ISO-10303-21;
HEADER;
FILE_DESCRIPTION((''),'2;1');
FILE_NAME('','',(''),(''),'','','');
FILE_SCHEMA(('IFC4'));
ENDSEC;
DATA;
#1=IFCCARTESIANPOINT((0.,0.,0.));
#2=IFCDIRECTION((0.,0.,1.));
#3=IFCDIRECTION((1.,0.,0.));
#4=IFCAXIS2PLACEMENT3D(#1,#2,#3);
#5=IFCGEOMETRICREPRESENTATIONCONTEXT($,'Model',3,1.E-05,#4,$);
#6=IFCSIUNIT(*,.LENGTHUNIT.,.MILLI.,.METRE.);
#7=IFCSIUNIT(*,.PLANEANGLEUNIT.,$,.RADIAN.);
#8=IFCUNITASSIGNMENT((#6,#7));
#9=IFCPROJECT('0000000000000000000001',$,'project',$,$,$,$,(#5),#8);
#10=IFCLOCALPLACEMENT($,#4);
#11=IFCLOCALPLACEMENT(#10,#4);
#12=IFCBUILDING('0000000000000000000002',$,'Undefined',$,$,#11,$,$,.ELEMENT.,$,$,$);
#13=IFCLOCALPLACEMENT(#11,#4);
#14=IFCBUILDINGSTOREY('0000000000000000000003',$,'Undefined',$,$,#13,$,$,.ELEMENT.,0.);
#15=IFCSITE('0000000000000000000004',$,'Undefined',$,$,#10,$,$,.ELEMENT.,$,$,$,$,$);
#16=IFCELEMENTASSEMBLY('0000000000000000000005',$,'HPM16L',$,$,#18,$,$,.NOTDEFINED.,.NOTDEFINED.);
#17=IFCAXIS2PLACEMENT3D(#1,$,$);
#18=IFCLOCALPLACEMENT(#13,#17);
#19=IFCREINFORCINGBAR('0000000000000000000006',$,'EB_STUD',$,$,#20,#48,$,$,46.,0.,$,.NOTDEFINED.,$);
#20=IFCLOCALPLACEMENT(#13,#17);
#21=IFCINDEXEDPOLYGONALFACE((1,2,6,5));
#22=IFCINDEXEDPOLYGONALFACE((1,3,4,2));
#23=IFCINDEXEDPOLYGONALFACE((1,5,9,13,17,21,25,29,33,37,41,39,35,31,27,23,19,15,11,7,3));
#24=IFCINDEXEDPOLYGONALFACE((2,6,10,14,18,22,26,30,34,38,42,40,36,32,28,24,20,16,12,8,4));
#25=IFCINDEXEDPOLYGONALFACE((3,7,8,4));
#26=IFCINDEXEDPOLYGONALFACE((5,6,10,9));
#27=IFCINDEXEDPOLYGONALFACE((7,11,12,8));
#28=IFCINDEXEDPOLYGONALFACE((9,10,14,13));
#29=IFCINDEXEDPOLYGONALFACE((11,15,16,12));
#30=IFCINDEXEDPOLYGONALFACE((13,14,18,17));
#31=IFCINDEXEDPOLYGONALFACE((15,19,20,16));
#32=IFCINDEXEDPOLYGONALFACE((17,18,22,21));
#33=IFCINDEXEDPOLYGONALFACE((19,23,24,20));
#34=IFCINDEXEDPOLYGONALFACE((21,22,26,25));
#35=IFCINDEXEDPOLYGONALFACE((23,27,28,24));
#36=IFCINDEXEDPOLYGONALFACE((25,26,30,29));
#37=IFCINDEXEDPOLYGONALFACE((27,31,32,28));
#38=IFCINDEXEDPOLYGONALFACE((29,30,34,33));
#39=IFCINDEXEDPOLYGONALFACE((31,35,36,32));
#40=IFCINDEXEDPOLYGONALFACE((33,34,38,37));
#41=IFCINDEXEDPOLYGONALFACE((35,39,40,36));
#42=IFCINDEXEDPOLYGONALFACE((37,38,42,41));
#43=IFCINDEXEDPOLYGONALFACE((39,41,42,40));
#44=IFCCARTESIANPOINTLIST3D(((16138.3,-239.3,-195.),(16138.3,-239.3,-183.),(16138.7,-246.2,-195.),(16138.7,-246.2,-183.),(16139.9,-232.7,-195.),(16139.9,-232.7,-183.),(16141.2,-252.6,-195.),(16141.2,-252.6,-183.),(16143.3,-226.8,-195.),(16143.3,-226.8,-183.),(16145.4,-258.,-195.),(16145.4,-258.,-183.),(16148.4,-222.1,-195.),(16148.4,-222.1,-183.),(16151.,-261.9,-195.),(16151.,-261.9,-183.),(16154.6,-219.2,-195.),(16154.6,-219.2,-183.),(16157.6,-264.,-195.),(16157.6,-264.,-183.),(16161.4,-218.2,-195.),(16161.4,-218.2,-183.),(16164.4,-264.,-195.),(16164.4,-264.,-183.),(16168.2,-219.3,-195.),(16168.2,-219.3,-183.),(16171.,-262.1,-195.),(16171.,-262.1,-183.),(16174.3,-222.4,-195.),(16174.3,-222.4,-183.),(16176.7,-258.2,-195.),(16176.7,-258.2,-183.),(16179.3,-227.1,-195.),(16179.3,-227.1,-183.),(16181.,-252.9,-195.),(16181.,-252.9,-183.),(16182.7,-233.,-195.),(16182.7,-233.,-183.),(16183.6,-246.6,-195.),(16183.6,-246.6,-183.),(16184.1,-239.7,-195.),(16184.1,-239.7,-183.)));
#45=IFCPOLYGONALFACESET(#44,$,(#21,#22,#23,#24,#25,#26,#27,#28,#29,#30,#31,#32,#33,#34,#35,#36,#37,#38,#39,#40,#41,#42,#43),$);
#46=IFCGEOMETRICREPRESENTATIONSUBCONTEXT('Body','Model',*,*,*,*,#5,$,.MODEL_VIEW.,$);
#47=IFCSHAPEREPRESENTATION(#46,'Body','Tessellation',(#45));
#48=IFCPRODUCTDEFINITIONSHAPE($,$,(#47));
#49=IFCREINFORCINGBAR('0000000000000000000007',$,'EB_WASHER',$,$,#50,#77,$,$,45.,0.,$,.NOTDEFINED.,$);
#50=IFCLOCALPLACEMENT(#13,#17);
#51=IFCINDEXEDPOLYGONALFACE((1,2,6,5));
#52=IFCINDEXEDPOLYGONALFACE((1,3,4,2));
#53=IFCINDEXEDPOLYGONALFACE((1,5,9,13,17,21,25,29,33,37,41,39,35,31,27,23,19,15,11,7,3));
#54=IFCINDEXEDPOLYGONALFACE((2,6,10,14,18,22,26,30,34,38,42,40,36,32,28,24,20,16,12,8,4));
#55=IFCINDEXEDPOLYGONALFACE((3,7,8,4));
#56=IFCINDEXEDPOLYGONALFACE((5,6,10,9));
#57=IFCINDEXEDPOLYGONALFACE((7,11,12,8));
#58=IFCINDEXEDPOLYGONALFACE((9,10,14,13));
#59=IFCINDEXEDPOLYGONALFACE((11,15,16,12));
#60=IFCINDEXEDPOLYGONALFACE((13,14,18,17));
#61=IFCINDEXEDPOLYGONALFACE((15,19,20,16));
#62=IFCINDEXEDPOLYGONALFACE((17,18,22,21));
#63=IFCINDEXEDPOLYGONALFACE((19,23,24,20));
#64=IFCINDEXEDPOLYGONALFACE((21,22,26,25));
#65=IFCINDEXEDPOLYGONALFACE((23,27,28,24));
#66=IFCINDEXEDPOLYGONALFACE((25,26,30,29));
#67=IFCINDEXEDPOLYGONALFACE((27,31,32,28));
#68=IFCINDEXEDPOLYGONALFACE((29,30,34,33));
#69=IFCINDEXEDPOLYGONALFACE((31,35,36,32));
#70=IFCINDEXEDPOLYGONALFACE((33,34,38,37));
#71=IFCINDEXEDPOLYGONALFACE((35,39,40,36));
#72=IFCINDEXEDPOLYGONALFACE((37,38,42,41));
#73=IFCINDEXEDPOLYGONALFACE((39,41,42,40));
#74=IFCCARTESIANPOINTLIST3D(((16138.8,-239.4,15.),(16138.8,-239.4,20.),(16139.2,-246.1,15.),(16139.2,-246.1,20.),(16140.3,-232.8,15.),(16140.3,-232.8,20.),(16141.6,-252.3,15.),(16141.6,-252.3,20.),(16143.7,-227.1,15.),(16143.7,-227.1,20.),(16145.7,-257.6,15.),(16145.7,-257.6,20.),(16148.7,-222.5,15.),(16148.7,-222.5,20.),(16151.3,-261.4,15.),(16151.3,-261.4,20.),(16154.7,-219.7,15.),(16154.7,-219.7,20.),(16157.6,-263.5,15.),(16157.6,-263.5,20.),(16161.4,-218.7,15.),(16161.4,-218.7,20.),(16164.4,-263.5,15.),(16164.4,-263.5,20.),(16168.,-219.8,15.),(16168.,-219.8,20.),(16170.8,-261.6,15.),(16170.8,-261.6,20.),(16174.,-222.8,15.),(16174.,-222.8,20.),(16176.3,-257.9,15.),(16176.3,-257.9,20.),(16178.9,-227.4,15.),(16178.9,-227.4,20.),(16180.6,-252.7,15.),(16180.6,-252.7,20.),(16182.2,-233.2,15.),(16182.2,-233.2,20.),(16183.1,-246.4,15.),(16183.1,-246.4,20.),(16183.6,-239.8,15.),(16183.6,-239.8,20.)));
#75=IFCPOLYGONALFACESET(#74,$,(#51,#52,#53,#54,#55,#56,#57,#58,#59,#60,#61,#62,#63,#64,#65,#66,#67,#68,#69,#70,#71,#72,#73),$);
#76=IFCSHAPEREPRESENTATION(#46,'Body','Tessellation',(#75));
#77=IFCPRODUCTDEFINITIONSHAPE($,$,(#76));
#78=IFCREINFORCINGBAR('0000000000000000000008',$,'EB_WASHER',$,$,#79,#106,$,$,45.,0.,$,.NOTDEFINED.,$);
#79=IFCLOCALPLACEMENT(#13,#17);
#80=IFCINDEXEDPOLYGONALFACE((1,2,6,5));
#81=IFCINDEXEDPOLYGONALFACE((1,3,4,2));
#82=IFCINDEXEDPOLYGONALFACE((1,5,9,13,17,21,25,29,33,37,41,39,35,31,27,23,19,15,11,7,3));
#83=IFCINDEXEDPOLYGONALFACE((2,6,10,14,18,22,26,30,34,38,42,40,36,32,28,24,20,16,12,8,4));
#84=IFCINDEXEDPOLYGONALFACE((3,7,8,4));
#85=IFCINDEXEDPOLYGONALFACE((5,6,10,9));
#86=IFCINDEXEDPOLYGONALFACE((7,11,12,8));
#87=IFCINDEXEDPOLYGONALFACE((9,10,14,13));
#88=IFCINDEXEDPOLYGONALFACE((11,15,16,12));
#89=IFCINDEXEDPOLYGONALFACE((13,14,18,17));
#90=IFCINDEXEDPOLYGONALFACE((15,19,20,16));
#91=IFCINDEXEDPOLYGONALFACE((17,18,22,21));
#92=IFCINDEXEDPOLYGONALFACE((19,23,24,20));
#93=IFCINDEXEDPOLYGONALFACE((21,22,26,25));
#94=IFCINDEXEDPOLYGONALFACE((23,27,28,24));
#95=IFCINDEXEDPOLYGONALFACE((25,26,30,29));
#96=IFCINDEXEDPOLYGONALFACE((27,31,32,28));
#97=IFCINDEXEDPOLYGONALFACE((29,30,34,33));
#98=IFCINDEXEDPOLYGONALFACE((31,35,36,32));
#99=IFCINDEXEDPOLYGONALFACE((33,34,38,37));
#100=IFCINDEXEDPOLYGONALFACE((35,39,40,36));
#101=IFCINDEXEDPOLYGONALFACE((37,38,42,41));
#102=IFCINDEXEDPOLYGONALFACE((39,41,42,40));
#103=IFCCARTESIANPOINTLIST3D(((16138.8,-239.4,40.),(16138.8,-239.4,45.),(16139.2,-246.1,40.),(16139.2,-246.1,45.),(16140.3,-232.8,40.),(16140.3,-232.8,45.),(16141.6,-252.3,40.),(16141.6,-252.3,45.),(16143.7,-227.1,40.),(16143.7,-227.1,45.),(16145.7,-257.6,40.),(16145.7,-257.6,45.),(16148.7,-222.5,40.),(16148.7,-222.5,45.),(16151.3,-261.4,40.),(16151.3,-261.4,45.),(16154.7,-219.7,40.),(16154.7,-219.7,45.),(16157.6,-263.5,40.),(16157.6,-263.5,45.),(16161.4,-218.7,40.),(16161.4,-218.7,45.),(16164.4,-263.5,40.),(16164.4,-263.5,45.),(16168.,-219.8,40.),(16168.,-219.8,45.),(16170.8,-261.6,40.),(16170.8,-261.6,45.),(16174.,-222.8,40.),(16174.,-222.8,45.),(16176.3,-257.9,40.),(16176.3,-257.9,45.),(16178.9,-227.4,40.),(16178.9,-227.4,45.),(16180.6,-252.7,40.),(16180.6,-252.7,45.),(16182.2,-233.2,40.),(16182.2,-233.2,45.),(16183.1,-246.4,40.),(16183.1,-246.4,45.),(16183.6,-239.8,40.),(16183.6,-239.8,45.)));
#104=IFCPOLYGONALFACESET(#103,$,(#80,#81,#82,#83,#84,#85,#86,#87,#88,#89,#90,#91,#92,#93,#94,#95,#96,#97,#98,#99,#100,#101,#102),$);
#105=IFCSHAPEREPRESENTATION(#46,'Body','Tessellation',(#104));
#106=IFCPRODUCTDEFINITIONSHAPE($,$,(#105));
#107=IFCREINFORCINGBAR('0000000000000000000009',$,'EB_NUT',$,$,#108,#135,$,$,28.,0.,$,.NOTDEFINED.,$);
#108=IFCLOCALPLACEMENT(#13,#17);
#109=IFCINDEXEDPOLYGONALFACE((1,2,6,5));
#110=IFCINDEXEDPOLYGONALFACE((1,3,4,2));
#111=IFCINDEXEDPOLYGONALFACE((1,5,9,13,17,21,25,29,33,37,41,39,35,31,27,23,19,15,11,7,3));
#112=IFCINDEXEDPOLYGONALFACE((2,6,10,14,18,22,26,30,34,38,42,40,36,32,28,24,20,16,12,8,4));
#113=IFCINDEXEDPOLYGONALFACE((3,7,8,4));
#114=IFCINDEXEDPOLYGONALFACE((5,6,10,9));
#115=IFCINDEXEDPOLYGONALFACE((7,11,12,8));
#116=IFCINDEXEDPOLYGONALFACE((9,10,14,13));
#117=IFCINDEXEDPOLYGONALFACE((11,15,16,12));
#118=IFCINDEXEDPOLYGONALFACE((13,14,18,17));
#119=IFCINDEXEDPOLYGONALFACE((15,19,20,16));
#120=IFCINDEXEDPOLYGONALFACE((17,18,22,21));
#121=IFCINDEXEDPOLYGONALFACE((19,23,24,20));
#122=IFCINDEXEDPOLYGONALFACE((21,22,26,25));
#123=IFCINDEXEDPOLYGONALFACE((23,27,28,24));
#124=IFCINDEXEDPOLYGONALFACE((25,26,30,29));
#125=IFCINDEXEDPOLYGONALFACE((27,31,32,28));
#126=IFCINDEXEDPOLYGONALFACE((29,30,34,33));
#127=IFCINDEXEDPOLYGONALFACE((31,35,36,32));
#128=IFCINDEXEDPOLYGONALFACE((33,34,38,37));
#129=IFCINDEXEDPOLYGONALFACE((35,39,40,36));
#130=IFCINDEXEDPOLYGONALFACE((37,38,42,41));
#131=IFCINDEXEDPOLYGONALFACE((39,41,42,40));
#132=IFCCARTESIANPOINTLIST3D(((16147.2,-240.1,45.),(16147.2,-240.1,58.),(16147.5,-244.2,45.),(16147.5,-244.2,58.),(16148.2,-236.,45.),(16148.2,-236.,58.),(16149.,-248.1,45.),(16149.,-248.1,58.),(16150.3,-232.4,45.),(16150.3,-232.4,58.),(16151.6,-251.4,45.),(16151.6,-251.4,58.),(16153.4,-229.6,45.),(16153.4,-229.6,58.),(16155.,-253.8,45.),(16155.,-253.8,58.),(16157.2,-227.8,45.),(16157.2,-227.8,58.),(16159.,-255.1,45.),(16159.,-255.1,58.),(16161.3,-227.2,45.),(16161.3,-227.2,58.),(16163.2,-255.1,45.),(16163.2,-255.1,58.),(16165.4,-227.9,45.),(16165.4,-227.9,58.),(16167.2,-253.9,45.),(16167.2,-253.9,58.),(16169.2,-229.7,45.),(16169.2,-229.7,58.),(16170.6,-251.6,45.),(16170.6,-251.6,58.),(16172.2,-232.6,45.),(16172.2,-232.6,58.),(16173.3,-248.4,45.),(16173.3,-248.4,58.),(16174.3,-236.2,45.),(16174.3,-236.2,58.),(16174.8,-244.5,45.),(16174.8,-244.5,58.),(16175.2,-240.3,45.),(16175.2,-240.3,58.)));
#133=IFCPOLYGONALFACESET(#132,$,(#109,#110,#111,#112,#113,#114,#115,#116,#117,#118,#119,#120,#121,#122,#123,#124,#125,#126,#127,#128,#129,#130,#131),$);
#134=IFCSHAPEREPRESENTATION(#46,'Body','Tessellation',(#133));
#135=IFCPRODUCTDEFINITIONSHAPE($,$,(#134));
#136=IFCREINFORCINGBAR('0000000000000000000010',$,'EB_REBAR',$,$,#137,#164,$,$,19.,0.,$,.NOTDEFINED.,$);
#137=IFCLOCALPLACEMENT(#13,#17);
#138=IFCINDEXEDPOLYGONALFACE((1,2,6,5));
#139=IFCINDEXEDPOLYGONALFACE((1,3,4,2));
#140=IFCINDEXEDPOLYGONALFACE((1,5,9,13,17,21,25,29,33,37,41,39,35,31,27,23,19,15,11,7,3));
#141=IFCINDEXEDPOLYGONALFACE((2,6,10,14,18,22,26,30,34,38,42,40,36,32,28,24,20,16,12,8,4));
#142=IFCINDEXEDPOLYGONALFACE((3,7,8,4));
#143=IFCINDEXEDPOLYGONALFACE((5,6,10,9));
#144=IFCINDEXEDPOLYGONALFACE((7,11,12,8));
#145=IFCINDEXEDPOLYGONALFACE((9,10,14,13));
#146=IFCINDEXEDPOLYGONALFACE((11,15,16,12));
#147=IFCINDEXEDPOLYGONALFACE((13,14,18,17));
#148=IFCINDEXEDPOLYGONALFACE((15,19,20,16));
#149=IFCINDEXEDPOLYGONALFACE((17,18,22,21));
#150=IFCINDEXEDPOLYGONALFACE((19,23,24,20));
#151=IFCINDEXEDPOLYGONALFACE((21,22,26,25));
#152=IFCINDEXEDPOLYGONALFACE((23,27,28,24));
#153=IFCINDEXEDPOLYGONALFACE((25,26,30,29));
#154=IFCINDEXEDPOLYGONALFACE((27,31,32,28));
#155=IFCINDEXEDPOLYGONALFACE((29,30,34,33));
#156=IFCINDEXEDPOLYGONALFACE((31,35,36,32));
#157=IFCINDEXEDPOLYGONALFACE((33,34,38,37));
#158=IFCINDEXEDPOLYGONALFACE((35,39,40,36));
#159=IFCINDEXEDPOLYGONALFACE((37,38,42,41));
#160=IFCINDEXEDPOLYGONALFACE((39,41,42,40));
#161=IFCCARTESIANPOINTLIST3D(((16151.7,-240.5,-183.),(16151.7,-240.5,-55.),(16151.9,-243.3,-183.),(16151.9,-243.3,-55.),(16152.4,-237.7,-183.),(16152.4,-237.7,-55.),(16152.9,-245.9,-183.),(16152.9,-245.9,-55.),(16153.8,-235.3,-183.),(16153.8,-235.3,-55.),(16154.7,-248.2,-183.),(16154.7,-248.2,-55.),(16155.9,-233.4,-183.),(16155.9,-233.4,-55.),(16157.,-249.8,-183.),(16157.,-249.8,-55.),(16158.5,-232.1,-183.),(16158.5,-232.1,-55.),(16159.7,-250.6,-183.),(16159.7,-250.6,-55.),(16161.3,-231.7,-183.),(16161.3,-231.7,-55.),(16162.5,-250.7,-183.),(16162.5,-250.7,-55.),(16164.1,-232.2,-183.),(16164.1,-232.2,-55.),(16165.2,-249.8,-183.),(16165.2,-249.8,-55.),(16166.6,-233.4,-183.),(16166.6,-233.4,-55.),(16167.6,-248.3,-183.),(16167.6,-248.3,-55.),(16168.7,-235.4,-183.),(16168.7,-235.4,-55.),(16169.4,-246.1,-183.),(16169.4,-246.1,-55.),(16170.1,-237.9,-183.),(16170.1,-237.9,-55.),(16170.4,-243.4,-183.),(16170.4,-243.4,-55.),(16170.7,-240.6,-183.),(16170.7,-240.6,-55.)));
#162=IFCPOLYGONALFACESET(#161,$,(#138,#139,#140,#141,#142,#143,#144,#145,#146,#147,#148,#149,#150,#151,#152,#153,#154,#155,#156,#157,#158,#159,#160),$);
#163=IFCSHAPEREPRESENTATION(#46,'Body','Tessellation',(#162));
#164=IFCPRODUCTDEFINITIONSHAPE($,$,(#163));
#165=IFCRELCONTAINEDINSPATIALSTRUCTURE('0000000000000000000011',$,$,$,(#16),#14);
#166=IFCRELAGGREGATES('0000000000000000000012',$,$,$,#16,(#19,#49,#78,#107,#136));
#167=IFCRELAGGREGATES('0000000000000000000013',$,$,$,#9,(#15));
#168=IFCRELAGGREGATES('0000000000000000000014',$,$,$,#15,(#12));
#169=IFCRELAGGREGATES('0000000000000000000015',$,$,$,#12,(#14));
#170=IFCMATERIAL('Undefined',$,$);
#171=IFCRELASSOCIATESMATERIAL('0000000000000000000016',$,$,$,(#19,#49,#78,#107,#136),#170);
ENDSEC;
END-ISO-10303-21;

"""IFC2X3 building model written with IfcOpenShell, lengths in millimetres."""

from ifc_helpers import new_model, entity, si_unit, frame, origin_with_axes, place, context, subcontext, project, spatial, source, transform, mapped, material, element, aggregate, save


model = new_model("IFC2X3")

# Units and contexts
model_context = context("Model", 3, precision=1e-05, world=origin_with_axes())
body_context = subcontext(model_context, "Body", "Model", "MODEL_VIEW")
ifc_project = project(units=[si_unit("LENGTHUNIT", "METRE", prefix="MILLI"), si_unit("PLANEANGLEUNIT", "RADIAN")], contexts=[model_context])

# Site, building, storey
site_placement = place(None, origin_with_axes())
site = spatial("IfcSite", under=ifc_project, at=site_placement, Name="Undefined", CompositionType="ELEMENT")
building_placement = place(site_placement, origin_with_axes())
building = spatial("IfcBuilding", under=site, at=building_placement, Name="Undefined", CompositionType="ELEMENT")
storey_placement = place(building_placement, origin_with_axes())
storey = spatial("IfcBuildingStorey", under=building, at=storey_placement, Name="Undefined", CompositionType="ELEMENT", Elevation=0.0)

# Element assembly
assembly_1_placement = place(storey_placement, origin_with_axes())
assembly_1 = element("IfcElementAssembly", 1, at=assembly_1_placement, inside=storey, Name="HPM16L", AssemblyPlace="NOTDEFINED", PredefinedType="NOTDEFINED")

# Reinforcing bars
ifc_material_1 = material(Name="Undefined")
shared_shape_1 = source(origin_with_axes(), body_context, "Body", "AdvancedSweptSolid", [
    entity("IfcSweptDiskSolid", entity("IfcTrimmedCurve", entity("IfcLine", entity("IfcCartesianPoint", [0.0, 0.0, 0.0]), entity("IfcVector", entity("IfcDirection", [1.0, 0.0, 0.0]), 1.0)), [entity("IfcParameterValue", 0.0)], [entity("IfcParameterValue", 12.0)], True, "PARAMETER"), 23.0, None, 0.0, 12.0),
])
reinforcing_bar_1_placement = place(assembly_1_placement, frame((16161.2, -241.2, -183.0), z_axis=(0.008664, 0.999962, 0.0), x_axis=(0.0, 0.0, -1.0)))
reinforcing_bar_1 = element("IfcReinforcingBar", 2, at=reinforcing_bar_1_placement, material=ifc_material_1, Name="EB_STUD", BarRole="NOTDEFINED", CrossSectionArea=0.0, NominalDiameter=46.0, context=body_context, shape_type="MappedRepresentation", body=[
    mapped(shared_shape_1, transform((0.0, 0.0, 0.0))),
])
shared_shape_2 = source(origin_with_axes(), body_context, "Body", "AdvancedSweptSolid", [
    entity("IfcSweptDiskSolid", entity("IfcTrimmedCurve", entity("IfcLine", entity("IfcCartesianPoint", [0.0, 0.0, 0.0]), entity("IfcVector", entity("IfcDirection", [1.0, 0.0, 0.0]), 1.0)), [entity("IfcParameterValue", 0.0)], [entity("IfcParameterValue", 5.0)], True, "PARAMETER"), 22.5, None, 0.0, 5.0),
])
reinforcing_bar_2_placement = place(assembly_1_placement, frame((16161.2, -241.2, 20.0), z_axis=(0.008664, 0.999962, 0.0), x_axis=(0.0, 0.0, -1.0)))
reinforcing_bar_2 = element("IfcReinforcingBar", 3, at=reinforcing_bar_2_placement, material=ifc_material_1, Name="EB_WASHER", BarRole="NOTDEFINED", CrossSectionArea=0.0, NominalDiameter=45.0, context=body_context, shape_type="MappedRepresentation", body=[
    mapped(shared_shape_2, transform((0.0, 0.0, 0.0))),
])
shared_shape_3 = source(origin_with_axes(), body_context, "Body", "AdvancedSweptSolid", [
    entity("IfcSweptDiskSolid", entity("IfcTrimmedCurve", entity("IfcLine", entity("IfcCartesianPoint", [0.0, 0.0, 0.0]), entity("IfcVector", entity("IfcDirection", [1.0, 0.0, 0.0]), 1.0)), [entity("IfcParameterValue", 0.0)], [entity("IfcParameterValue", 5.0)], True, "PARAMETER"), 22.5, None, 0.0, 5.0),
])
reinforcing_bar_3_placement = place(assembly_1_placement, frame((16161.2, -241.2, 45.0), z_axis=(0.008664, 0.999962, 0.0), x_axis=(0.0, 0.0, -1.0)))
reinforcing_bar_3 = element("IfcReinforcingBar", 4, at=reinforcing_bar_3_placement, material=ifc_material_1, Name="EB_WASHER", BarRole="NOTDEFINED", CrossSectionArea=0.0, NominalDiameter=45.0, context=body_context, shape_type="MappedRepresentation", body=[
    mapped(shared_shape_3, transform((0.0, 0.0, 0.0))),
])
shared_shape_4 = source(origin_with_axes(), body_context, "Body", "AdvancedSweptSolid", [
    entity("IfcSweptDiskSolid", entity("IfcTrimmedCurve", entity("IfcLine", entity("IfcCartesianPoint", [0.0, 0.0, 0.0]), entity("IfcVector", entity("IfcDirection", [1.0, 0.0, 0.0]), 1.0)), [entity("IfcParameterValue", 0.0)], [entity("IfcParameterValue", 13.0)], True, "PARAMETER"), 14.0, None, 0.0, 13.0),
])
reinforcing_bar_4_placement = place(assembly_1_placement, frame((16161.2, -241.2, 58.0), z_axis=(0.008664, 0.999962, 0.0), x_axis=(0.0, 0.0, -1.0)))
reinforcing_bar_4 = element("IfcReinforcingBar", 5, at=reinforcing_bar_4_placement, material=ifc_material_1, Name="EB_NUT", BarRole="NOTDEFINED", CrossSectionArea=0.0, NominalDiameter=28.0, context=body_context, shape_type="MappedRepresentation", body=[
    mapped(shared_shape_4, transform((0.0, 0.0, 0.0))),
])
shared_shape_5 = source(origin_with_axes(), body_context, "Body", "AdvancedSweptSolid", [
    entity("IfcSweptDiskSolid", entity("IfcTrimmedCurve", entity("IfcLine", entity("IfcCartesianPoint", [0.0, 0.0, 0.0]), entity("IfcVector", entity("IfcDirection", [1.0, 0.0, 0.0]), 1.0)), [entity("IfcParameterValue", 0.0)], [entity("IfcParameterValue", 128.0)], True, "PARAMETER"), 9.5, None, 0.0, 128.0),
])
reinforcing_bar_5_placement = place(assembly_1_placement, frame((16161.2, -241.2, -55.0), z_axis=(0.008664, 0.999962, 0.0), x_axis=(0.0, 0.0, -1.0)))
reinforcing_bar_5 = element("IfcReinforcingBar", 6, at=reinforcing_bar_5_placement, material=ifc_material_1, Name="EB_REBAR", BarRole="NOTDEFINED", CrossSectionArea=0.0, NominalDiameter=19.0, context=body_context, shape_type="MappedRepresentation", body=[
    mapped(shared_shape_5, transform((0.0, 0.0, 0.0))),
])
aggregate(assembly_1, [reinforcing_bar_1, reinforcing_bar_2, reinforcing_bar_3, reinforcing_bar_4, reinforcing_bar_5])

save(model, "model.ifc")
